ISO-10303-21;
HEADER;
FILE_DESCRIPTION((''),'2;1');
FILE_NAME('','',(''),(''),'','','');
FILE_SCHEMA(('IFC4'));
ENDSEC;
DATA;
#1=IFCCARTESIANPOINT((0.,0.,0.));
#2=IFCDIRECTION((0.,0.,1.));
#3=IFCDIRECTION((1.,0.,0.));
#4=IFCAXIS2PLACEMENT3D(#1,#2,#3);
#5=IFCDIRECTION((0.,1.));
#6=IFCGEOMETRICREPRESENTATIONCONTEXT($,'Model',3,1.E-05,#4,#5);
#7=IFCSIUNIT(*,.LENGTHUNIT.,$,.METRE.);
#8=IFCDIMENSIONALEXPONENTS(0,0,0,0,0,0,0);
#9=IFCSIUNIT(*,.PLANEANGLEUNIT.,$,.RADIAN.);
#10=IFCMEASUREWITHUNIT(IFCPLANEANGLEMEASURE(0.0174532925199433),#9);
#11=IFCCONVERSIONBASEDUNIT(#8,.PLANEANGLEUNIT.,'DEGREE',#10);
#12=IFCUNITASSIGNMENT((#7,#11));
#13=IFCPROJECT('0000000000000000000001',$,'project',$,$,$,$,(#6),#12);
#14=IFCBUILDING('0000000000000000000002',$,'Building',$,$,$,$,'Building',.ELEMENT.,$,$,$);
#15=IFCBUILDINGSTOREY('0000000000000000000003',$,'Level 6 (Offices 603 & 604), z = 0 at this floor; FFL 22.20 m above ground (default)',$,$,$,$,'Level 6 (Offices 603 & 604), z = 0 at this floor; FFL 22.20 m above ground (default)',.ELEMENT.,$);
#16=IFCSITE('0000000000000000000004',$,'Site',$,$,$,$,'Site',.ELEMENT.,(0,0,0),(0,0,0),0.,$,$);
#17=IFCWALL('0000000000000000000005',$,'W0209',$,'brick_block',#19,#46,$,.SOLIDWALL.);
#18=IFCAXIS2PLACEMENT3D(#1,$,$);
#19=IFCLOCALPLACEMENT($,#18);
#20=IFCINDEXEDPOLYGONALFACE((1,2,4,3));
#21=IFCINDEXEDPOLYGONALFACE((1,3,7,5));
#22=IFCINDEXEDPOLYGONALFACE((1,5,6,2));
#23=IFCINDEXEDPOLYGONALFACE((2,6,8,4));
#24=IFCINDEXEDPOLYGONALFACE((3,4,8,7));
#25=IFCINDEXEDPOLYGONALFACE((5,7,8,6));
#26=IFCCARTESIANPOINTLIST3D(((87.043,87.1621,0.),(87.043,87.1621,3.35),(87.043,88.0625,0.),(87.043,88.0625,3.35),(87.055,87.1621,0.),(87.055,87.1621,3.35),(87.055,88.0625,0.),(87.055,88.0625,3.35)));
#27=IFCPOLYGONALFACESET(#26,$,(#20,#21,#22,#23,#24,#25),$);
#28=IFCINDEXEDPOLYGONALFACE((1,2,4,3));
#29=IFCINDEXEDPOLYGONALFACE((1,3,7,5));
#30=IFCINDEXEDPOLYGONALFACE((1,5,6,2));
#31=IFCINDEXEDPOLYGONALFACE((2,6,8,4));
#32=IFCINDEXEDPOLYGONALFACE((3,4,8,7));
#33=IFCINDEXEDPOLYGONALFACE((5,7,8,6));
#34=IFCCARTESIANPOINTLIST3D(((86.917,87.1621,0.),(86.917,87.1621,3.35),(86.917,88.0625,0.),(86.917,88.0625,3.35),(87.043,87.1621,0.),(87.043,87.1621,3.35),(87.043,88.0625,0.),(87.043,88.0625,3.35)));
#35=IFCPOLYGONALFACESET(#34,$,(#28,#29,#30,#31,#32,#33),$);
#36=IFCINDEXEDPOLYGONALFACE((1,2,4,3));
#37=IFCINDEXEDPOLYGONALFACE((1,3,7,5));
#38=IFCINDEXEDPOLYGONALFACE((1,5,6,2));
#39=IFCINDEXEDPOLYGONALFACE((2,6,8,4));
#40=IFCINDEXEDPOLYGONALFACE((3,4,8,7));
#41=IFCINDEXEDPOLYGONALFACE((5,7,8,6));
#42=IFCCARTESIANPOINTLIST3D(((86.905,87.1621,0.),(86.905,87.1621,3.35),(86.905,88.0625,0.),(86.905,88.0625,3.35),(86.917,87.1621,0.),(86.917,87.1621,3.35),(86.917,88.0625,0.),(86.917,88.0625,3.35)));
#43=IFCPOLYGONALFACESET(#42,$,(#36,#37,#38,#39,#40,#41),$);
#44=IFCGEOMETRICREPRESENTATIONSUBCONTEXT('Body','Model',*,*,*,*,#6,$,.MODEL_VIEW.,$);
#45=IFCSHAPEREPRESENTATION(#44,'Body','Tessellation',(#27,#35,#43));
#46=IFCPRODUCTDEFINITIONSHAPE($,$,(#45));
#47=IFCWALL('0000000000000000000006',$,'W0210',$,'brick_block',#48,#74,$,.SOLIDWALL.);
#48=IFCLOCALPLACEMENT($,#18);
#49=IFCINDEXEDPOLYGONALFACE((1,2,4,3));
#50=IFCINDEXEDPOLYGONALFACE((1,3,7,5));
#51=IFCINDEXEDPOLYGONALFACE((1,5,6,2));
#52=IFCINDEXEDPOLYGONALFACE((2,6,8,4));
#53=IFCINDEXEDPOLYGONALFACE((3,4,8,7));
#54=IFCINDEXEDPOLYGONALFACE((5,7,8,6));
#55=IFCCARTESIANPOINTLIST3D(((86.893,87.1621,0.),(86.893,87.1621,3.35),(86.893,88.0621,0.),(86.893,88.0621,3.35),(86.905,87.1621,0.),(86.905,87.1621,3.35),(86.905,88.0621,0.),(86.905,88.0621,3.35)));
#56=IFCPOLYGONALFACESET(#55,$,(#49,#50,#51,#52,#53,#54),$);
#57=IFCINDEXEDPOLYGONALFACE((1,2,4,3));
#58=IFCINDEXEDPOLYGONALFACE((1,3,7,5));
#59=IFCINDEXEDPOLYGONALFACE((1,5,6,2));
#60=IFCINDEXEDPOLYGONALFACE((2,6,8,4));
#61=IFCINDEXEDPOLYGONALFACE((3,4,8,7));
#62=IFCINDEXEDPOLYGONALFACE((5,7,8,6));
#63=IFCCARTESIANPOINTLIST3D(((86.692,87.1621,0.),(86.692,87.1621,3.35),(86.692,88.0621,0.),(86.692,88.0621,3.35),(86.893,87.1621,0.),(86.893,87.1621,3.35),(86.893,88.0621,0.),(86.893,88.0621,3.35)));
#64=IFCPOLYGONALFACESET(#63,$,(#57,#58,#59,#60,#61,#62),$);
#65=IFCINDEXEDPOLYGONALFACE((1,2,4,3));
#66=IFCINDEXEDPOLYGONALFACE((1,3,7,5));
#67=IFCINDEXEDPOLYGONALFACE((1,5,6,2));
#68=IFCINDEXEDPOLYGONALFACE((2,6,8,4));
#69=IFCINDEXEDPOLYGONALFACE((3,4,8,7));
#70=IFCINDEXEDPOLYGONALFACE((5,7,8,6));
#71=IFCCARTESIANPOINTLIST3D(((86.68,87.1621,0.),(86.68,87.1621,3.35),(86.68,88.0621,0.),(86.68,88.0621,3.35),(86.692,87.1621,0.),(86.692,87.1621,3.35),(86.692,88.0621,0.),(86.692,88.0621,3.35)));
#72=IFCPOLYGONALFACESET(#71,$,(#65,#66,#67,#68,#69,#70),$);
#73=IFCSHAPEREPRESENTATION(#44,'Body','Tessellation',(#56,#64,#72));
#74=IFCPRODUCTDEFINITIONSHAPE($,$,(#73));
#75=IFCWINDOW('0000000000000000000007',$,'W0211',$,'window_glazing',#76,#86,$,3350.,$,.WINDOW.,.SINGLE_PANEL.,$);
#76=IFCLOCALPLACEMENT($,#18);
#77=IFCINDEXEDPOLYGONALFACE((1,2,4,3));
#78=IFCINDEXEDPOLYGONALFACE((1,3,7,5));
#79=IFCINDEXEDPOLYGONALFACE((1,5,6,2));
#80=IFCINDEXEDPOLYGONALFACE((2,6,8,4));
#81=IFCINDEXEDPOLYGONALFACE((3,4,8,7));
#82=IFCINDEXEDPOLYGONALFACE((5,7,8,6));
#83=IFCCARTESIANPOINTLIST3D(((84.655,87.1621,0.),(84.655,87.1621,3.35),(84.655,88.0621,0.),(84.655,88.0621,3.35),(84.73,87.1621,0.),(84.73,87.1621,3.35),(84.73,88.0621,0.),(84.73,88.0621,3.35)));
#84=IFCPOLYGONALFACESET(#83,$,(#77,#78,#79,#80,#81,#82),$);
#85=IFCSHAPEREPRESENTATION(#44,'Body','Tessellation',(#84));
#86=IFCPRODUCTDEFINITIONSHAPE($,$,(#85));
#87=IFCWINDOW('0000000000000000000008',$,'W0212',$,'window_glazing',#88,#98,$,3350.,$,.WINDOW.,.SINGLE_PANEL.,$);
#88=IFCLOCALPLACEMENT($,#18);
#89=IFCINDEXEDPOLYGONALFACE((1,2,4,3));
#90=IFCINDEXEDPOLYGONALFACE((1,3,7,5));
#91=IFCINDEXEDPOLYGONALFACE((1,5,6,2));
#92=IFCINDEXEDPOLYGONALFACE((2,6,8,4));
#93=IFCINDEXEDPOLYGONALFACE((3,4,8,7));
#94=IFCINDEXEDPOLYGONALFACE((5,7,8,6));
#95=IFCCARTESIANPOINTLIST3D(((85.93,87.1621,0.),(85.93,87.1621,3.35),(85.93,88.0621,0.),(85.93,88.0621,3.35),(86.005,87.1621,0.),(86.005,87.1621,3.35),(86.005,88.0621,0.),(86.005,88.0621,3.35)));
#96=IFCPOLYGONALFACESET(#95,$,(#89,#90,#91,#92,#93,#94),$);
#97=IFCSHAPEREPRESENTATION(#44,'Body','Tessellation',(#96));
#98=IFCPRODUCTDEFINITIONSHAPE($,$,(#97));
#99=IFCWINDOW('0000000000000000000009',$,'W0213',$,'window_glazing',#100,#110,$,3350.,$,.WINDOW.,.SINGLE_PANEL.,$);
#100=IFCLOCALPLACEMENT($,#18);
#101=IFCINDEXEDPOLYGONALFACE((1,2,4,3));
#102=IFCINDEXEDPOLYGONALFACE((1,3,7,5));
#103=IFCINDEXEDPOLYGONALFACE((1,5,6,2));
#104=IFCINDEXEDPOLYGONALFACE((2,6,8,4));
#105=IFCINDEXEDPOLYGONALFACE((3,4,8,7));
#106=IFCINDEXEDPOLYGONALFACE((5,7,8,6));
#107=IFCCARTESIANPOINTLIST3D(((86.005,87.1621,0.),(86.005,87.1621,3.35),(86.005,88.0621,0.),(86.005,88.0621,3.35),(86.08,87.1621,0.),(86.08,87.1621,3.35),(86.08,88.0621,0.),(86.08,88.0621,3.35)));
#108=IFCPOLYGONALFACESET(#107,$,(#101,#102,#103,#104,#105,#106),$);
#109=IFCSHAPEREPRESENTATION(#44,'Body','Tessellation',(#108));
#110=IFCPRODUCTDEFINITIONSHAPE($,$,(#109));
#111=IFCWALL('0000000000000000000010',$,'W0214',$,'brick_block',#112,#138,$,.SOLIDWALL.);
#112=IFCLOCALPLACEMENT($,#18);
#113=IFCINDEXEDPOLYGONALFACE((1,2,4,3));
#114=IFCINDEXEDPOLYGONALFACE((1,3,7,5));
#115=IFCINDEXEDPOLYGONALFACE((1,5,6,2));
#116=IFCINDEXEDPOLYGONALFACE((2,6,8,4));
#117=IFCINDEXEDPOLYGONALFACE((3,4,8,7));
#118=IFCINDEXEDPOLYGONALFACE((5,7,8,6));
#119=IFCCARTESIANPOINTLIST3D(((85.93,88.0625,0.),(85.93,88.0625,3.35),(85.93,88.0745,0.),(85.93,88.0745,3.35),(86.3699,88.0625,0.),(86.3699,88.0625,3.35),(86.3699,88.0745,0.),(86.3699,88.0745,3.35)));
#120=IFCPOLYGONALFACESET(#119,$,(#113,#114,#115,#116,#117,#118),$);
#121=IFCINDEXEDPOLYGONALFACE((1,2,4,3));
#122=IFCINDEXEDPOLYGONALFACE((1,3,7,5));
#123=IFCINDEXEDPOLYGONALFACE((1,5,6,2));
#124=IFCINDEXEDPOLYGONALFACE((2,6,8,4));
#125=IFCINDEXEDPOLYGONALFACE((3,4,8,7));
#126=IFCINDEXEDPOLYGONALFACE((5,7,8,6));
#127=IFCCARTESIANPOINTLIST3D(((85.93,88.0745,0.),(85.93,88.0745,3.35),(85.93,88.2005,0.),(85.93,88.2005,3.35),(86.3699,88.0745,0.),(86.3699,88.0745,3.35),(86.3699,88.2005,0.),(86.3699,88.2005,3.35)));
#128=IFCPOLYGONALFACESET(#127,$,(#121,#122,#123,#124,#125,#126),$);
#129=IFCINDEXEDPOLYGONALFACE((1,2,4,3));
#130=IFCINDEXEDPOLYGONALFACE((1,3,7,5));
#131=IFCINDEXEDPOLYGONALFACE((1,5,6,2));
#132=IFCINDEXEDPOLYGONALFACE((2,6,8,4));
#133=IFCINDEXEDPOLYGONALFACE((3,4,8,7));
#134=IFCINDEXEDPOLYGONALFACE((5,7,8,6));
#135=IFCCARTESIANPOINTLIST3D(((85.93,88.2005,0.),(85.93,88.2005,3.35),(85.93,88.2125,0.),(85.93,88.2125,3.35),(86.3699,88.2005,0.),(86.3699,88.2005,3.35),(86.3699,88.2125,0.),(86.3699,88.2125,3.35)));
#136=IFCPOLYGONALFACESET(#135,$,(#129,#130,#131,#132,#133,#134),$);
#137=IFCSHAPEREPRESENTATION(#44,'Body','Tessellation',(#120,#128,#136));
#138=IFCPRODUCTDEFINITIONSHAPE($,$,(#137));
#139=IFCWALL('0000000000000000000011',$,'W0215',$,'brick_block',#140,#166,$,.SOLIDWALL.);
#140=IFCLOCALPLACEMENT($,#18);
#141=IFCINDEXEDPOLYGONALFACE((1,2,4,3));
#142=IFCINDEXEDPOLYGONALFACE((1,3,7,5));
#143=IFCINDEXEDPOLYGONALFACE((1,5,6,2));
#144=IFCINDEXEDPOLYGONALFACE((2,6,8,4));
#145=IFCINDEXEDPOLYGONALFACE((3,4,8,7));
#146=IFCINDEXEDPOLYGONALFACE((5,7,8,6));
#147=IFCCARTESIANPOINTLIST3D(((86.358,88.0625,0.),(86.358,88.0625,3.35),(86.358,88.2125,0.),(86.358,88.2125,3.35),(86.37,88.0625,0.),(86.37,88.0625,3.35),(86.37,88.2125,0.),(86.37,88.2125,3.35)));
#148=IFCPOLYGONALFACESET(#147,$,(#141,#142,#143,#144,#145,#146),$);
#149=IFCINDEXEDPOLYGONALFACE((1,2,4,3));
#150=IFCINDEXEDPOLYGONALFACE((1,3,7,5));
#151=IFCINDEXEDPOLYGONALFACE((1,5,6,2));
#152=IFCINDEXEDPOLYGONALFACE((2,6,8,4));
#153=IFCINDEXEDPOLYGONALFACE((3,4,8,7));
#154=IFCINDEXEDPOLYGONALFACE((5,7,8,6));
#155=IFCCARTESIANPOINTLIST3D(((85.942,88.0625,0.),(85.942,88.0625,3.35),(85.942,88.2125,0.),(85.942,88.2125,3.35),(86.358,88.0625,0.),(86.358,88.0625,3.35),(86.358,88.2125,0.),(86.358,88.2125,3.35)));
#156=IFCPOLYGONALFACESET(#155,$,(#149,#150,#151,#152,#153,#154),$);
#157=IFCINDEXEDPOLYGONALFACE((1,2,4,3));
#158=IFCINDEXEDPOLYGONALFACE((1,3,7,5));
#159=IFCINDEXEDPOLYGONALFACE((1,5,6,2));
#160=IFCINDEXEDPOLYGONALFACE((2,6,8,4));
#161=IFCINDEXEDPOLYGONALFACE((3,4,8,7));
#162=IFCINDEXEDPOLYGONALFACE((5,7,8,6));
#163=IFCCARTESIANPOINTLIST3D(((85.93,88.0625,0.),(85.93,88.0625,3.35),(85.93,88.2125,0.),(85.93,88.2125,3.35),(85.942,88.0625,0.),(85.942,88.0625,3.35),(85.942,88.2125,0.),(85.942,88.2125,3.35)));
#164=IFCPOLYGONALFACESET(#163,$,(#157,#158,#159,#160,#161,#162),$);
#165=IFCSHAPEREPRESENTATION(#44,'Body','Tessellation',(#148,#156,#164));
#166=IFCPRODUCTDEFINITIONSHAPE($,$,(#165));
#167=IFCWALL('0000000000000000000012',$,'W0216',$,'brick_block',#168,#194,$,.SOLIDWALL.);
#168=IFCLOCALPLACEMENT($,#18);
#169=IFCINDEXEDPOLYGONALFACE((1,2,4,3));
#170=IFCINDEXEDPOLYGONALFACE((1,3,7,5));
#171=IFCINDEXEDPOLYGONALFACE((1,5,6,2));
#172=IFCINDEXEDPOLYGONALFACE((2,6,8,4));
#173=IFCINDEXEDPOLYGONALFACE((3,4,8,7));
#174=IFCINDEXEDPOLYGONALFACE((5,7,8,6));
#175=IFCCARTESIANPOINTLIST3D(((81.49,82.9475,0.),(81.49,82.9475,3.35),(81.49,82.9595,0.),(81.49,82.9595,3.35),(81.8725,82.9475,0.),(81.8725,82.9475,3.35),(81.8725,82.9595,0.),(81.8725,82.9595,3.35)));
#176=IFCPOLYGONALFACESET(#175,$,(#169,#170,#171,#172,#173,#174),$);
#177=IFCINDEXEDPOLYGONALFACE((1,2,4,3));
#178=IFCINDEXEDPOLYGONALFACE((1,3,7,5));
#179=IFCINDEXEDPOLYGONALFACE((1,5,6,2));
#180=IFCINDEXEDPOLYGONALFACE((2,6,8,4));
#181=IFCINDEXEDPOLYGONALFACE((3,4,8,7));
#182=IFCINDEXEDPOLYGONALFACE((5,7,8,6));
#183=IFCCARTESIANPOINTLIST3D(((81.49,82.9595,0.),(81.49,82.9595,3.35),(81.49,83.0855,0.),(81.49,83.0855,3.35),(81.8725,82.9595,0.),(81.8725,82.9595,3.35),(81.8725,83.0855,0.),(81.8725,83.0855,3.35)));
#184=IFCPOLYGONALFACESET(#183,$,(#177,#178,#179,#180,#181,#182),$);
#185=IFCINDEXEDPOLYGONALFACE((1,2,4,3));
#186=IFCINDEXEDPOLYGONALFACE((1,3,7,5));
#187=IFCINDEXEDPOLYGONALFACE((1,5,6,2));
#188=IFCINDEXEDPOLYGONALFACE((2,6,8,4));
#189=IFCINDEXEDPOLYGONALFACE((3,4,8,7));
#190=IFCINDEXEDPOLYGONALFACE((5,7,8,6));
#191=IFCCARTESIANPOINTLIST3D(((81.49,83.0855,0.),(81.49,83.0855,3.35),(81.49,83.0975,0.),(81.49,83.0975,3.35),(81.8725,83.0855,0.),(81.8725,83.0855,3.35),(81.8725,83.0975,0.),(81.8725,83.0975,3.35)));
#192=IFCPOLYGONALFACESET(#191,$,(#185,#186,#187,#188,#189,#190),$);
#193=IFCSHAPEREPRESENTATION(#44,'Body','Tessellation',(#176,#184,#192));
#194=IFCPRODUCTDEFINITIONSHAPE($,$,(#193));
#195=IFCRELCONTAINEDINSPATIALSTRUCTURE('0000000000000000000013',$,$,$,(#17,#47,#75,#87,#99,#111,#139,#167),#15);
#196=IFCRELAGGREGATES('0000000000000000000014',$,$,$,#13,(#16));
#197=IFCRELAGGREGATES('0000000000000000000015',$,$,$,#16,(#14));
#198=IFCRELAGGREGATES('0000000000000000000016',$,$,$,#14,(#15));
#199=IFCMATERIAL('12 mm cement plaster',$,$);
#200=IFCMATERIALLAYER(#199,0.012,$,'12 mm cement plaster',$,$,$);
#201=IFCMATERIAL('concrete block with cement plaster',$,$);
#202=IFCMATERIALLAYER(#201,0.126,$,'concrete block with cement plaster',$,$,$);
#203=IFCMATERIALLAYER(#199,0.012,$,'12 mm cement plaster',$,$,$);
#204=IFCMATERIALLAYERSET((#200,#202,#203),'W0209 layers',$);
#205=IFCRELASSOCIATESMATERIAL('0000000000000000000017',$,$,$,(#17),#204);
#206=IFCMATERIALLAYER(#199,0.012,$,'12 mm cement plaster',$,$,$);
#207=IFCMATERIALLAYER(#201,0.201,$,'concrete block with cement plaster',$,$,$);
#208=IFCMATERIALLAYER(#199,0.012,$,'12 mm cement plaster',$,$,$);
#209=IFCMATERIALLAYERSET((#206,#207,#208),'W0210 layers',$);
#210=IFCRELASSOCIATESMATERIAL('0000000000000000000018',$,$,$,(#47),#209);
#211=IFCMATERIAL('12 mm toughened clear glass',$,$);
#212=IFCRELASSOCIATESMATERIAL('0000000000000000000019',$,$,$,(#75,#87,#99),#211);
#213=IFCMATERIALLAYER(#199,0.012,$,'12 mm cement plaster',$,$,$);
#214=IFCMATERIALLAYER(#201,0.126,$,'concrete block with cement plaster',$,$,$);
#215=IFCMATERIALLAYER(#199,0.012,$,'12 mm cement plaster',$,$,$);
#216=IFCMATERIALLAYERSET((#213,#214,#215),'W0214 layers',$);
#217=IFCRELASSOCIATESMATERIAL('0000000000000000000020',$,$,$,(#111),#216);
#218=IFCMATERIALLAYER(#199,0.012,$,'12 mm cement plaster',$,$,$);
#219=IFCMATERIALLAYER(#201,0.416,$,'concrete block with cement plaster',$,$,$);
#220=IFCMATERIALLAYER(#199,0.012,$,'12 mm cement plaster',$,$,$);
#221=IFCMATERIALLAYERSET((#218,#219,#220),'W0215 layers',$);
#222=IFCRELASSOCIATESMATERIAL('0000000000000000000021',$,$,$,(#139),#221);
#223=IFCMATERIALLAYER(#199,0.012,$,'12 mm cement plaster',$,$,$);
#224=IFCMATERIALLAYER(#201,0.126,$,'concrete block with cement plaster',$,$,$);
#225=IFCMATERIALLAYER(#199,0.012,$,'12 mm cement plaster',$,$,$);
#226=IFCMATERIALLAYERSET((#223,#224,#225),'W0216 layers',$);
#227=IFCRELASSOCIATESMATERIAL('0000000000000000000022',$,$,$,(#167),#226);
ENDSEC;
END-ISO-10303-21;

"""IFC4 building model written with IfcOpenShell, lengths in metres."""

from ifc_helpers import new_model, entity, si_unit, converted_unit, direction, frame, frame_2d, origin_with_axes, place, context, subcontext, project, spatial, rectangle, extrude, material, layer, layer_set, layer_usage, element, save


model = new_model("IFC4")

# Units and contexts
model_context = context("Model", 3, precision=1e-05, world=origin_with_axes(), true_north=direction((0.0, 1.0)))
body_context = subcontext(model_context, "Body", "Model", "MODEL_VIEW")
ifc_project = project(units=[si_unit("LENGTHUNIT", "METRE"), converted_unit("PLANEANGLEUNIT", "DEGREE", entity("IfcPlaneAngleMeasure", 0.0174532925199433), si_unit("PLANEANGLEUNIT", "RADIAN"), dimensions=[0, 0, 0, 0, 0, 0, 0])], contexts=[model_context])

# Site, building, storey
site = spatial("IfcSite", under=ifc_project, Name="Site", LongName="Site", CompositionType="ELEMENT", RefLatitude=(0, 0, 0), RefLongitude=(0, 0, 0), RefElevation=0.0)
building = spatial("IfcBuilding", under=site, Name="Building", LongName="Building", CompositionType="ELEMENT")
storey = spatial("IfcBuildingStorey", under=building, Name="Level 6 (Offices 603 & 604), z = 0 at this floor; FFL 22.20 m above ground (default)", LongName="Level 6 (Offices 603 & 604), z = 0 at this floor; FFL 22.20 m above ground (default)", CompositionType="ELEMENT")

# Shared definitions
ifc_material_1 = material(Name="12 mm cement plaster")
ifc_material_2 = material(Name="concrete block with cement plaster")
placement = place(None, origin_with_axes())

# Shared definitions
ifc_material_3 = material(Name="12 mm toughened clear glass")

# Walls
ifc_layer_1 = layer(ifc_material_1, 0.012, Name="12 mm cement plaster")
ifc_layer_2 = layer(ifc_material_2, 0.126, Name="concrete block with cement plaster")
ifc_layer_3 = layer(ifc_material_1, 0.012, Name="12 mm cement plaster")
ifc_layer_set_1 = layer_set([ifc_layer_1, ifc_layer_2, ifc_layer_3], Name="W0209 layers")
ifc_layer_usage_1 = layer_usage(ifc_layer_set_1, "AXIS2", "POSITIVE", -0.075)
element("IfcWall", 1, at=placement, inside=storey, material=ifc_layer_usage_1, Name="W0209", ObjectType="brick_block", PredefinedType="SOLIDWALL", context=body_context, shape_type="SweptSolid", body=[
    extrude(rectangle(XDim=0.9004, YDim=0.012, at=frame_2d((0.0, 0.0), x_axis=(0.0, 1.0))), frame((87.049, 87.6123, 0.0), z_axis=(0.0, 0.0, 1.0), x_axis=(1.0, 0.0, 0.0)), (0.0, 0.0, 1.0), 3.35),
    extrude(rectangle(XDim=0.9004, YDim=0.126, at=frame_2d((-0.069, 0.0), x_axis=(0.0, 1.0))), frame((87.049, 87.6123, 0.0), z_axis=(0.0, 0.0, 1.0), x_axis=(1.0, 0.0, 0.0)), (0.0, 0.0, 1.0), 3.35),
    extrude(rectangle(XDim=0.9004, YDim=0.012, at=frame_2d((-0.138, 0.0), x_axis=(0.0, 1.0))), frame((87.049, 87.6123, 0.0), z_axis=(0.0, 0.0, 1.0), x_axis=(1.0, 0.0, 0.0)), (0.0, 0.0, 1.0), 3.35),
])
ifc_layer_4 = layer(ifc_material_1, 0.012, Name="12 mm cement plaster")
ifc_layer_5 = layer(ifc_material_2, 0.201, Name="concrete block with cement plaster")
ifc_layer_6 = layer(ifc_material_1, 0.012, Name="12 mm cement plaster")
ifc_layer_set_2 = layer_set([ifc_layer_4, ifc_layer_5, ifc_layer_6], Name="W0210 layers")
ifc_layer_usage_2 = layer_usage(ifc_layer_set_2, "AXIS2", "POSITIVE", -0.1125)
element("IfcWall", 2, at=placement, inside=storey, material=ifc_layer_usage_2, Name="W0210", ObjectType="brick_block", PredefinedType="SOLIDWALL", context=body_context, shape_type="SweptSolid", body=[
    extrude(rectangle(XDim=0.9, YDim=0.012, at=frame_2d((0.0, 0.0), x_axis=(0.0, 1.0))), frame((86.899, 87.6121, 0.0), z_axis=(0.0, 0.0, 1.0), x_axis=(1.0, 0.0, 0.0)), (0.0, 0.0, 1.0), 3.35),
    extrude(rectangle(XDim=0.9, YDim=0.201, at=frame_2d((-0.1065, 0.0), x_axis=(0.0, 1.0))), frame((86.899, 87.6121, 0.0), z_axis=(0.0, 0.0, 1.0), x_axis=(1.0, 0.0, 0.0)), (0.0, 0.0, 1.0), 3.35),
    extrude(rectangle(XDim=0.9, YDim=0.012, at=frame_2d((-0.213, 0.0), x_axis=(0.0, 1.0))), frame((86.899, 87.6121, 0.0), z_axis=(0.0, 0.0, 1.0), x_axis=(1.0, 0.0, 0.0)), (0.0, 0.0, 1.0), 3.35),
])

# Windows
element("IfcWindow", 3, at=placement, inside=storey, material=ifc_material_3, Name="W0211", ObjectType="window_glazing", OverallHeight=3350.0, PartitioningType="SINGLE_PANEL", PredefinedType="WINDOW", context=body_context, shape_type="SweptSolid", body=[
    extrude(rectangle(XDim=0.9, YDim=0.075, at=frame_2d((0.0, 0.0), x_axis=(0.0, 1.0))), frame((84.6925, 87.6121, 0.0), z_axis=(0.0, 0.0, 1.0), x_axis=(1.0, 0.0, 0.0)), (0.0, 0.0, 1.0), 3.35),
])
element("IfcWindow", 4, at=placement, inside=storey, material=ifc_material_3, Name="W0212", ObjectType="window_glazing", OverallHeight=3350.0, PartitioningType="SINGLE_PANEL", PredefinedType="WINDOW", context=body_context, shape_type="SweptSolid", body=[
    extrude(rectangle(XDim=0.9, YDim=0.075, at=frame_2d((0.0, 0.0), x_axis=(0.0, 1.0))), frame((85.9675, 87.6121, 0.0), z_axis=(0.0, 0.0, 1.0), x_axis=(1.0, 0.0, 0.0)), (0.0, 0.0, 1.0), 3.35),
])
element("IfcWindow", 5, at=placement, inside=storey, material=ifc_material_3, Name="W0213", ObjectType="window_glazing", OverallHeight=3350.0, PartitioningType="SINGLE_PANEL", PredefinedType="WINDOW", context=body_context, shape_type="SweptSolid", body=[
    extrude(rectangle(XDim=0.9, YDim=0.075, at=frame_2d((0.0, 0.0), x_axis=(0.0, 1.0))), frame((86.0425, 87.6121, 0.0), z_axis=(0.0, 0.0, 1.0), x_axis=(1.0, 0.0, 0.0)), (0.0, 0.0, 1.0), 3.35),
])

# Walls
ifc_layer_7 = layer(ifc_material_1, 0.012, Name="12 mm cement plaster")
ifc_layer_8 = layer(ifc_material_2, 0.126, Name="concrete block with cement plaster")
ifc_layer_9 = layer(ifc_material_1, 0.012, Name="12 mm cement plaster")
ifc_layer_set_3 = layer_set([ifc_layer_7, ifc_layer_8, ifc_layer_9], Name="W0214 layers")
ifc_layer_usage_3 = layer_usage(ifc_layer_set_3, "AXIS2", "POSITIVE", -0.075)
element("IfcWall", 6, at=placement, inside=storey, material=ifc_layer_usage_3, Name="W0214", ObjectType="brick_block", PredefinedType="SOLIDWALL", context=body_context, shape_type="SweptSolid", body=[
    extrude(rectangle(XDim=0.4399, YDim=0.012, at=frame_2d((0.0, 0.0), x_axis=(1.0, 0.0))), frame((86.15, 88.0685, 0.0), z_axis=(0.0, 0.0, 1.0), x_axis=(1.0, 0.0, 0.0)), (0.0, 0.0, 1.0), 3.35),
    extrude(rectangle(XDim=0.4399, YDim=0.126, at=frame_2d((0.0, 0.069), x_axis=(1.0, 0.0))), frame((86.15, 88.0685, 0.0), z_axis=(0.0, 0.0, 1.0), x_axis=(1.0, 0.0, 0.0)), (0.0, 0.0, 1.0), 3.35),
    extrude(rectangle(XDim=0.4399, YDim=0.012, at=frame_2d((0.0, 0.138), x_axis=(1.0, 0.0))), frame((86.15, 88.0685, 0.0), z_axis=(0.0, 0.0, 1.0), x_axis=(1.0, 0.0, 0.0)), (0.0, 0.0, 1.0), 3.35),
])
ifc_layer_10 = layer(ifc_material_1, 0.012, Name="12 mm cement plaster")
ifc_layer_11 = layer(ifc_material_2, 0.416, Name="concrete block with cement plaster")
ifc_layer_12 = layer(ifc_material_1, 0.012, Name="12 mm cement plaster")
ifc_layer_set_4 = layer_set([ifc_layer_10, ifc_layer_11, ifc_layer_12], Name="W0215 layers")
ifc_layer_usage_4 = layer_usage(ifc_layer_set_4, "AXIS2", "POSITIVE", -0.22)
element("IfcWall", 7, at=placement, inside=storey, material=ifc_layer_usage_4, Name="W0215", ObjectType="brick_block", PredefinedType="SOLIDWALL", context=body_context, shape_type="SweptSolid", body=[
    extrude(rectangle(XDim=0.15, YDim=0.012, at=frame_2d((0.0, 0.0), x_axis=(0.0, 1.0))), frame((86.364, 88.1375, 0.0), z_axis=(0.0, 0.0, 1.0), x_axis=(1.0, 0.0, 0.0)), (0.0, 0.0, 1.0), 3.35),
    extrude(rectangle(XDim=0.15, YDim=0.416, at=frame_2d((-0.214, 0.0), x_axis=(0.0, 1.0))), frame((86.364, 88.1375, 0.0), z_axis=(0.0, 0.0, 1.0), x_axis=(1.0, 0.0, 0.0)), (0.0, 0.0, 1.0), 3.35),
    extrude(rectangle(XDim=0.15, YDim=0.012, at=frame_2d((-0.428, 0.0), x_axis=(0.0, 1.0))), frame((86.364, 88.1375, 0.0), z_axis=(0.0, 0.0, 1.0), x_axis=(1.0, 0.0, 0.0)), (0.0, 0.0, 1.0), 3.35),
])
ifc_layer_13 = layer(ifc_material_1, 0.012, Name="12 mm cement plaster")
ifc_layer_14 = layer(ifc_material_2, 0.126, Name="concrete block with cement plaster")
ifc_layer_15 = layer(ifc_material_1, 0.012, Name="12 mm cement plaster")
ifc_layer_set_5 = layer_set([ifc_layer_13, ifc_layer_14, ifc_layer_15], Name="W0216 layers")
ifc_layer_usage_5 = layer_usage(ifc_layer_set_5, "AXIS2", "POSITIVE", -0.075)
element("IfcWall", 8, at=placement, inside=storey, material=ifc_layer_usage_5, Name="W0216", ObjectType="brick_block", PredefinedType="SOLIDWALL", context=body_context, shape_type="SweptSolid", body=[
    extrude(rectangle(XDim=0.3825, YDim=0.012, at=frame_2d((0.0, 0.0), x_axis=(1.0, 0.0))), frame((81.6813, 82.9535, 0.0), z_axis=(0.0, 0.0, 1.0), x_axis=(1.0, 0.0, 0.0)), (0.0, 0.0, 1.0), 3.35),
    extrude(rectangle(XDim=0.3825, YDim=0.126, at=frame_2d((0.0, 0.069), x_axis=(1.0, 0.0))), frame((81.6813, 82.9535, 0.0), z_axis=(0.0, 0.0, 1.0), x_axis=(1.0, 0.0, 0.0)), (0.0, 0.0, 1.0), 3.35),
    extrude(rectangle(XDim=0.3825, YDim=0.012, at=frame_2d((0.0, 0.138), x_axis=(1.0, 0.0))), frame((81.6813, 82.9535, 0.0), z_axis=(0.0, 0.0, 1.0), x_axis=(1.0, 0.0, 0.0)), (0.0, 0.0, 1.0), 3.35),
])

save(model, "model.ifc")
